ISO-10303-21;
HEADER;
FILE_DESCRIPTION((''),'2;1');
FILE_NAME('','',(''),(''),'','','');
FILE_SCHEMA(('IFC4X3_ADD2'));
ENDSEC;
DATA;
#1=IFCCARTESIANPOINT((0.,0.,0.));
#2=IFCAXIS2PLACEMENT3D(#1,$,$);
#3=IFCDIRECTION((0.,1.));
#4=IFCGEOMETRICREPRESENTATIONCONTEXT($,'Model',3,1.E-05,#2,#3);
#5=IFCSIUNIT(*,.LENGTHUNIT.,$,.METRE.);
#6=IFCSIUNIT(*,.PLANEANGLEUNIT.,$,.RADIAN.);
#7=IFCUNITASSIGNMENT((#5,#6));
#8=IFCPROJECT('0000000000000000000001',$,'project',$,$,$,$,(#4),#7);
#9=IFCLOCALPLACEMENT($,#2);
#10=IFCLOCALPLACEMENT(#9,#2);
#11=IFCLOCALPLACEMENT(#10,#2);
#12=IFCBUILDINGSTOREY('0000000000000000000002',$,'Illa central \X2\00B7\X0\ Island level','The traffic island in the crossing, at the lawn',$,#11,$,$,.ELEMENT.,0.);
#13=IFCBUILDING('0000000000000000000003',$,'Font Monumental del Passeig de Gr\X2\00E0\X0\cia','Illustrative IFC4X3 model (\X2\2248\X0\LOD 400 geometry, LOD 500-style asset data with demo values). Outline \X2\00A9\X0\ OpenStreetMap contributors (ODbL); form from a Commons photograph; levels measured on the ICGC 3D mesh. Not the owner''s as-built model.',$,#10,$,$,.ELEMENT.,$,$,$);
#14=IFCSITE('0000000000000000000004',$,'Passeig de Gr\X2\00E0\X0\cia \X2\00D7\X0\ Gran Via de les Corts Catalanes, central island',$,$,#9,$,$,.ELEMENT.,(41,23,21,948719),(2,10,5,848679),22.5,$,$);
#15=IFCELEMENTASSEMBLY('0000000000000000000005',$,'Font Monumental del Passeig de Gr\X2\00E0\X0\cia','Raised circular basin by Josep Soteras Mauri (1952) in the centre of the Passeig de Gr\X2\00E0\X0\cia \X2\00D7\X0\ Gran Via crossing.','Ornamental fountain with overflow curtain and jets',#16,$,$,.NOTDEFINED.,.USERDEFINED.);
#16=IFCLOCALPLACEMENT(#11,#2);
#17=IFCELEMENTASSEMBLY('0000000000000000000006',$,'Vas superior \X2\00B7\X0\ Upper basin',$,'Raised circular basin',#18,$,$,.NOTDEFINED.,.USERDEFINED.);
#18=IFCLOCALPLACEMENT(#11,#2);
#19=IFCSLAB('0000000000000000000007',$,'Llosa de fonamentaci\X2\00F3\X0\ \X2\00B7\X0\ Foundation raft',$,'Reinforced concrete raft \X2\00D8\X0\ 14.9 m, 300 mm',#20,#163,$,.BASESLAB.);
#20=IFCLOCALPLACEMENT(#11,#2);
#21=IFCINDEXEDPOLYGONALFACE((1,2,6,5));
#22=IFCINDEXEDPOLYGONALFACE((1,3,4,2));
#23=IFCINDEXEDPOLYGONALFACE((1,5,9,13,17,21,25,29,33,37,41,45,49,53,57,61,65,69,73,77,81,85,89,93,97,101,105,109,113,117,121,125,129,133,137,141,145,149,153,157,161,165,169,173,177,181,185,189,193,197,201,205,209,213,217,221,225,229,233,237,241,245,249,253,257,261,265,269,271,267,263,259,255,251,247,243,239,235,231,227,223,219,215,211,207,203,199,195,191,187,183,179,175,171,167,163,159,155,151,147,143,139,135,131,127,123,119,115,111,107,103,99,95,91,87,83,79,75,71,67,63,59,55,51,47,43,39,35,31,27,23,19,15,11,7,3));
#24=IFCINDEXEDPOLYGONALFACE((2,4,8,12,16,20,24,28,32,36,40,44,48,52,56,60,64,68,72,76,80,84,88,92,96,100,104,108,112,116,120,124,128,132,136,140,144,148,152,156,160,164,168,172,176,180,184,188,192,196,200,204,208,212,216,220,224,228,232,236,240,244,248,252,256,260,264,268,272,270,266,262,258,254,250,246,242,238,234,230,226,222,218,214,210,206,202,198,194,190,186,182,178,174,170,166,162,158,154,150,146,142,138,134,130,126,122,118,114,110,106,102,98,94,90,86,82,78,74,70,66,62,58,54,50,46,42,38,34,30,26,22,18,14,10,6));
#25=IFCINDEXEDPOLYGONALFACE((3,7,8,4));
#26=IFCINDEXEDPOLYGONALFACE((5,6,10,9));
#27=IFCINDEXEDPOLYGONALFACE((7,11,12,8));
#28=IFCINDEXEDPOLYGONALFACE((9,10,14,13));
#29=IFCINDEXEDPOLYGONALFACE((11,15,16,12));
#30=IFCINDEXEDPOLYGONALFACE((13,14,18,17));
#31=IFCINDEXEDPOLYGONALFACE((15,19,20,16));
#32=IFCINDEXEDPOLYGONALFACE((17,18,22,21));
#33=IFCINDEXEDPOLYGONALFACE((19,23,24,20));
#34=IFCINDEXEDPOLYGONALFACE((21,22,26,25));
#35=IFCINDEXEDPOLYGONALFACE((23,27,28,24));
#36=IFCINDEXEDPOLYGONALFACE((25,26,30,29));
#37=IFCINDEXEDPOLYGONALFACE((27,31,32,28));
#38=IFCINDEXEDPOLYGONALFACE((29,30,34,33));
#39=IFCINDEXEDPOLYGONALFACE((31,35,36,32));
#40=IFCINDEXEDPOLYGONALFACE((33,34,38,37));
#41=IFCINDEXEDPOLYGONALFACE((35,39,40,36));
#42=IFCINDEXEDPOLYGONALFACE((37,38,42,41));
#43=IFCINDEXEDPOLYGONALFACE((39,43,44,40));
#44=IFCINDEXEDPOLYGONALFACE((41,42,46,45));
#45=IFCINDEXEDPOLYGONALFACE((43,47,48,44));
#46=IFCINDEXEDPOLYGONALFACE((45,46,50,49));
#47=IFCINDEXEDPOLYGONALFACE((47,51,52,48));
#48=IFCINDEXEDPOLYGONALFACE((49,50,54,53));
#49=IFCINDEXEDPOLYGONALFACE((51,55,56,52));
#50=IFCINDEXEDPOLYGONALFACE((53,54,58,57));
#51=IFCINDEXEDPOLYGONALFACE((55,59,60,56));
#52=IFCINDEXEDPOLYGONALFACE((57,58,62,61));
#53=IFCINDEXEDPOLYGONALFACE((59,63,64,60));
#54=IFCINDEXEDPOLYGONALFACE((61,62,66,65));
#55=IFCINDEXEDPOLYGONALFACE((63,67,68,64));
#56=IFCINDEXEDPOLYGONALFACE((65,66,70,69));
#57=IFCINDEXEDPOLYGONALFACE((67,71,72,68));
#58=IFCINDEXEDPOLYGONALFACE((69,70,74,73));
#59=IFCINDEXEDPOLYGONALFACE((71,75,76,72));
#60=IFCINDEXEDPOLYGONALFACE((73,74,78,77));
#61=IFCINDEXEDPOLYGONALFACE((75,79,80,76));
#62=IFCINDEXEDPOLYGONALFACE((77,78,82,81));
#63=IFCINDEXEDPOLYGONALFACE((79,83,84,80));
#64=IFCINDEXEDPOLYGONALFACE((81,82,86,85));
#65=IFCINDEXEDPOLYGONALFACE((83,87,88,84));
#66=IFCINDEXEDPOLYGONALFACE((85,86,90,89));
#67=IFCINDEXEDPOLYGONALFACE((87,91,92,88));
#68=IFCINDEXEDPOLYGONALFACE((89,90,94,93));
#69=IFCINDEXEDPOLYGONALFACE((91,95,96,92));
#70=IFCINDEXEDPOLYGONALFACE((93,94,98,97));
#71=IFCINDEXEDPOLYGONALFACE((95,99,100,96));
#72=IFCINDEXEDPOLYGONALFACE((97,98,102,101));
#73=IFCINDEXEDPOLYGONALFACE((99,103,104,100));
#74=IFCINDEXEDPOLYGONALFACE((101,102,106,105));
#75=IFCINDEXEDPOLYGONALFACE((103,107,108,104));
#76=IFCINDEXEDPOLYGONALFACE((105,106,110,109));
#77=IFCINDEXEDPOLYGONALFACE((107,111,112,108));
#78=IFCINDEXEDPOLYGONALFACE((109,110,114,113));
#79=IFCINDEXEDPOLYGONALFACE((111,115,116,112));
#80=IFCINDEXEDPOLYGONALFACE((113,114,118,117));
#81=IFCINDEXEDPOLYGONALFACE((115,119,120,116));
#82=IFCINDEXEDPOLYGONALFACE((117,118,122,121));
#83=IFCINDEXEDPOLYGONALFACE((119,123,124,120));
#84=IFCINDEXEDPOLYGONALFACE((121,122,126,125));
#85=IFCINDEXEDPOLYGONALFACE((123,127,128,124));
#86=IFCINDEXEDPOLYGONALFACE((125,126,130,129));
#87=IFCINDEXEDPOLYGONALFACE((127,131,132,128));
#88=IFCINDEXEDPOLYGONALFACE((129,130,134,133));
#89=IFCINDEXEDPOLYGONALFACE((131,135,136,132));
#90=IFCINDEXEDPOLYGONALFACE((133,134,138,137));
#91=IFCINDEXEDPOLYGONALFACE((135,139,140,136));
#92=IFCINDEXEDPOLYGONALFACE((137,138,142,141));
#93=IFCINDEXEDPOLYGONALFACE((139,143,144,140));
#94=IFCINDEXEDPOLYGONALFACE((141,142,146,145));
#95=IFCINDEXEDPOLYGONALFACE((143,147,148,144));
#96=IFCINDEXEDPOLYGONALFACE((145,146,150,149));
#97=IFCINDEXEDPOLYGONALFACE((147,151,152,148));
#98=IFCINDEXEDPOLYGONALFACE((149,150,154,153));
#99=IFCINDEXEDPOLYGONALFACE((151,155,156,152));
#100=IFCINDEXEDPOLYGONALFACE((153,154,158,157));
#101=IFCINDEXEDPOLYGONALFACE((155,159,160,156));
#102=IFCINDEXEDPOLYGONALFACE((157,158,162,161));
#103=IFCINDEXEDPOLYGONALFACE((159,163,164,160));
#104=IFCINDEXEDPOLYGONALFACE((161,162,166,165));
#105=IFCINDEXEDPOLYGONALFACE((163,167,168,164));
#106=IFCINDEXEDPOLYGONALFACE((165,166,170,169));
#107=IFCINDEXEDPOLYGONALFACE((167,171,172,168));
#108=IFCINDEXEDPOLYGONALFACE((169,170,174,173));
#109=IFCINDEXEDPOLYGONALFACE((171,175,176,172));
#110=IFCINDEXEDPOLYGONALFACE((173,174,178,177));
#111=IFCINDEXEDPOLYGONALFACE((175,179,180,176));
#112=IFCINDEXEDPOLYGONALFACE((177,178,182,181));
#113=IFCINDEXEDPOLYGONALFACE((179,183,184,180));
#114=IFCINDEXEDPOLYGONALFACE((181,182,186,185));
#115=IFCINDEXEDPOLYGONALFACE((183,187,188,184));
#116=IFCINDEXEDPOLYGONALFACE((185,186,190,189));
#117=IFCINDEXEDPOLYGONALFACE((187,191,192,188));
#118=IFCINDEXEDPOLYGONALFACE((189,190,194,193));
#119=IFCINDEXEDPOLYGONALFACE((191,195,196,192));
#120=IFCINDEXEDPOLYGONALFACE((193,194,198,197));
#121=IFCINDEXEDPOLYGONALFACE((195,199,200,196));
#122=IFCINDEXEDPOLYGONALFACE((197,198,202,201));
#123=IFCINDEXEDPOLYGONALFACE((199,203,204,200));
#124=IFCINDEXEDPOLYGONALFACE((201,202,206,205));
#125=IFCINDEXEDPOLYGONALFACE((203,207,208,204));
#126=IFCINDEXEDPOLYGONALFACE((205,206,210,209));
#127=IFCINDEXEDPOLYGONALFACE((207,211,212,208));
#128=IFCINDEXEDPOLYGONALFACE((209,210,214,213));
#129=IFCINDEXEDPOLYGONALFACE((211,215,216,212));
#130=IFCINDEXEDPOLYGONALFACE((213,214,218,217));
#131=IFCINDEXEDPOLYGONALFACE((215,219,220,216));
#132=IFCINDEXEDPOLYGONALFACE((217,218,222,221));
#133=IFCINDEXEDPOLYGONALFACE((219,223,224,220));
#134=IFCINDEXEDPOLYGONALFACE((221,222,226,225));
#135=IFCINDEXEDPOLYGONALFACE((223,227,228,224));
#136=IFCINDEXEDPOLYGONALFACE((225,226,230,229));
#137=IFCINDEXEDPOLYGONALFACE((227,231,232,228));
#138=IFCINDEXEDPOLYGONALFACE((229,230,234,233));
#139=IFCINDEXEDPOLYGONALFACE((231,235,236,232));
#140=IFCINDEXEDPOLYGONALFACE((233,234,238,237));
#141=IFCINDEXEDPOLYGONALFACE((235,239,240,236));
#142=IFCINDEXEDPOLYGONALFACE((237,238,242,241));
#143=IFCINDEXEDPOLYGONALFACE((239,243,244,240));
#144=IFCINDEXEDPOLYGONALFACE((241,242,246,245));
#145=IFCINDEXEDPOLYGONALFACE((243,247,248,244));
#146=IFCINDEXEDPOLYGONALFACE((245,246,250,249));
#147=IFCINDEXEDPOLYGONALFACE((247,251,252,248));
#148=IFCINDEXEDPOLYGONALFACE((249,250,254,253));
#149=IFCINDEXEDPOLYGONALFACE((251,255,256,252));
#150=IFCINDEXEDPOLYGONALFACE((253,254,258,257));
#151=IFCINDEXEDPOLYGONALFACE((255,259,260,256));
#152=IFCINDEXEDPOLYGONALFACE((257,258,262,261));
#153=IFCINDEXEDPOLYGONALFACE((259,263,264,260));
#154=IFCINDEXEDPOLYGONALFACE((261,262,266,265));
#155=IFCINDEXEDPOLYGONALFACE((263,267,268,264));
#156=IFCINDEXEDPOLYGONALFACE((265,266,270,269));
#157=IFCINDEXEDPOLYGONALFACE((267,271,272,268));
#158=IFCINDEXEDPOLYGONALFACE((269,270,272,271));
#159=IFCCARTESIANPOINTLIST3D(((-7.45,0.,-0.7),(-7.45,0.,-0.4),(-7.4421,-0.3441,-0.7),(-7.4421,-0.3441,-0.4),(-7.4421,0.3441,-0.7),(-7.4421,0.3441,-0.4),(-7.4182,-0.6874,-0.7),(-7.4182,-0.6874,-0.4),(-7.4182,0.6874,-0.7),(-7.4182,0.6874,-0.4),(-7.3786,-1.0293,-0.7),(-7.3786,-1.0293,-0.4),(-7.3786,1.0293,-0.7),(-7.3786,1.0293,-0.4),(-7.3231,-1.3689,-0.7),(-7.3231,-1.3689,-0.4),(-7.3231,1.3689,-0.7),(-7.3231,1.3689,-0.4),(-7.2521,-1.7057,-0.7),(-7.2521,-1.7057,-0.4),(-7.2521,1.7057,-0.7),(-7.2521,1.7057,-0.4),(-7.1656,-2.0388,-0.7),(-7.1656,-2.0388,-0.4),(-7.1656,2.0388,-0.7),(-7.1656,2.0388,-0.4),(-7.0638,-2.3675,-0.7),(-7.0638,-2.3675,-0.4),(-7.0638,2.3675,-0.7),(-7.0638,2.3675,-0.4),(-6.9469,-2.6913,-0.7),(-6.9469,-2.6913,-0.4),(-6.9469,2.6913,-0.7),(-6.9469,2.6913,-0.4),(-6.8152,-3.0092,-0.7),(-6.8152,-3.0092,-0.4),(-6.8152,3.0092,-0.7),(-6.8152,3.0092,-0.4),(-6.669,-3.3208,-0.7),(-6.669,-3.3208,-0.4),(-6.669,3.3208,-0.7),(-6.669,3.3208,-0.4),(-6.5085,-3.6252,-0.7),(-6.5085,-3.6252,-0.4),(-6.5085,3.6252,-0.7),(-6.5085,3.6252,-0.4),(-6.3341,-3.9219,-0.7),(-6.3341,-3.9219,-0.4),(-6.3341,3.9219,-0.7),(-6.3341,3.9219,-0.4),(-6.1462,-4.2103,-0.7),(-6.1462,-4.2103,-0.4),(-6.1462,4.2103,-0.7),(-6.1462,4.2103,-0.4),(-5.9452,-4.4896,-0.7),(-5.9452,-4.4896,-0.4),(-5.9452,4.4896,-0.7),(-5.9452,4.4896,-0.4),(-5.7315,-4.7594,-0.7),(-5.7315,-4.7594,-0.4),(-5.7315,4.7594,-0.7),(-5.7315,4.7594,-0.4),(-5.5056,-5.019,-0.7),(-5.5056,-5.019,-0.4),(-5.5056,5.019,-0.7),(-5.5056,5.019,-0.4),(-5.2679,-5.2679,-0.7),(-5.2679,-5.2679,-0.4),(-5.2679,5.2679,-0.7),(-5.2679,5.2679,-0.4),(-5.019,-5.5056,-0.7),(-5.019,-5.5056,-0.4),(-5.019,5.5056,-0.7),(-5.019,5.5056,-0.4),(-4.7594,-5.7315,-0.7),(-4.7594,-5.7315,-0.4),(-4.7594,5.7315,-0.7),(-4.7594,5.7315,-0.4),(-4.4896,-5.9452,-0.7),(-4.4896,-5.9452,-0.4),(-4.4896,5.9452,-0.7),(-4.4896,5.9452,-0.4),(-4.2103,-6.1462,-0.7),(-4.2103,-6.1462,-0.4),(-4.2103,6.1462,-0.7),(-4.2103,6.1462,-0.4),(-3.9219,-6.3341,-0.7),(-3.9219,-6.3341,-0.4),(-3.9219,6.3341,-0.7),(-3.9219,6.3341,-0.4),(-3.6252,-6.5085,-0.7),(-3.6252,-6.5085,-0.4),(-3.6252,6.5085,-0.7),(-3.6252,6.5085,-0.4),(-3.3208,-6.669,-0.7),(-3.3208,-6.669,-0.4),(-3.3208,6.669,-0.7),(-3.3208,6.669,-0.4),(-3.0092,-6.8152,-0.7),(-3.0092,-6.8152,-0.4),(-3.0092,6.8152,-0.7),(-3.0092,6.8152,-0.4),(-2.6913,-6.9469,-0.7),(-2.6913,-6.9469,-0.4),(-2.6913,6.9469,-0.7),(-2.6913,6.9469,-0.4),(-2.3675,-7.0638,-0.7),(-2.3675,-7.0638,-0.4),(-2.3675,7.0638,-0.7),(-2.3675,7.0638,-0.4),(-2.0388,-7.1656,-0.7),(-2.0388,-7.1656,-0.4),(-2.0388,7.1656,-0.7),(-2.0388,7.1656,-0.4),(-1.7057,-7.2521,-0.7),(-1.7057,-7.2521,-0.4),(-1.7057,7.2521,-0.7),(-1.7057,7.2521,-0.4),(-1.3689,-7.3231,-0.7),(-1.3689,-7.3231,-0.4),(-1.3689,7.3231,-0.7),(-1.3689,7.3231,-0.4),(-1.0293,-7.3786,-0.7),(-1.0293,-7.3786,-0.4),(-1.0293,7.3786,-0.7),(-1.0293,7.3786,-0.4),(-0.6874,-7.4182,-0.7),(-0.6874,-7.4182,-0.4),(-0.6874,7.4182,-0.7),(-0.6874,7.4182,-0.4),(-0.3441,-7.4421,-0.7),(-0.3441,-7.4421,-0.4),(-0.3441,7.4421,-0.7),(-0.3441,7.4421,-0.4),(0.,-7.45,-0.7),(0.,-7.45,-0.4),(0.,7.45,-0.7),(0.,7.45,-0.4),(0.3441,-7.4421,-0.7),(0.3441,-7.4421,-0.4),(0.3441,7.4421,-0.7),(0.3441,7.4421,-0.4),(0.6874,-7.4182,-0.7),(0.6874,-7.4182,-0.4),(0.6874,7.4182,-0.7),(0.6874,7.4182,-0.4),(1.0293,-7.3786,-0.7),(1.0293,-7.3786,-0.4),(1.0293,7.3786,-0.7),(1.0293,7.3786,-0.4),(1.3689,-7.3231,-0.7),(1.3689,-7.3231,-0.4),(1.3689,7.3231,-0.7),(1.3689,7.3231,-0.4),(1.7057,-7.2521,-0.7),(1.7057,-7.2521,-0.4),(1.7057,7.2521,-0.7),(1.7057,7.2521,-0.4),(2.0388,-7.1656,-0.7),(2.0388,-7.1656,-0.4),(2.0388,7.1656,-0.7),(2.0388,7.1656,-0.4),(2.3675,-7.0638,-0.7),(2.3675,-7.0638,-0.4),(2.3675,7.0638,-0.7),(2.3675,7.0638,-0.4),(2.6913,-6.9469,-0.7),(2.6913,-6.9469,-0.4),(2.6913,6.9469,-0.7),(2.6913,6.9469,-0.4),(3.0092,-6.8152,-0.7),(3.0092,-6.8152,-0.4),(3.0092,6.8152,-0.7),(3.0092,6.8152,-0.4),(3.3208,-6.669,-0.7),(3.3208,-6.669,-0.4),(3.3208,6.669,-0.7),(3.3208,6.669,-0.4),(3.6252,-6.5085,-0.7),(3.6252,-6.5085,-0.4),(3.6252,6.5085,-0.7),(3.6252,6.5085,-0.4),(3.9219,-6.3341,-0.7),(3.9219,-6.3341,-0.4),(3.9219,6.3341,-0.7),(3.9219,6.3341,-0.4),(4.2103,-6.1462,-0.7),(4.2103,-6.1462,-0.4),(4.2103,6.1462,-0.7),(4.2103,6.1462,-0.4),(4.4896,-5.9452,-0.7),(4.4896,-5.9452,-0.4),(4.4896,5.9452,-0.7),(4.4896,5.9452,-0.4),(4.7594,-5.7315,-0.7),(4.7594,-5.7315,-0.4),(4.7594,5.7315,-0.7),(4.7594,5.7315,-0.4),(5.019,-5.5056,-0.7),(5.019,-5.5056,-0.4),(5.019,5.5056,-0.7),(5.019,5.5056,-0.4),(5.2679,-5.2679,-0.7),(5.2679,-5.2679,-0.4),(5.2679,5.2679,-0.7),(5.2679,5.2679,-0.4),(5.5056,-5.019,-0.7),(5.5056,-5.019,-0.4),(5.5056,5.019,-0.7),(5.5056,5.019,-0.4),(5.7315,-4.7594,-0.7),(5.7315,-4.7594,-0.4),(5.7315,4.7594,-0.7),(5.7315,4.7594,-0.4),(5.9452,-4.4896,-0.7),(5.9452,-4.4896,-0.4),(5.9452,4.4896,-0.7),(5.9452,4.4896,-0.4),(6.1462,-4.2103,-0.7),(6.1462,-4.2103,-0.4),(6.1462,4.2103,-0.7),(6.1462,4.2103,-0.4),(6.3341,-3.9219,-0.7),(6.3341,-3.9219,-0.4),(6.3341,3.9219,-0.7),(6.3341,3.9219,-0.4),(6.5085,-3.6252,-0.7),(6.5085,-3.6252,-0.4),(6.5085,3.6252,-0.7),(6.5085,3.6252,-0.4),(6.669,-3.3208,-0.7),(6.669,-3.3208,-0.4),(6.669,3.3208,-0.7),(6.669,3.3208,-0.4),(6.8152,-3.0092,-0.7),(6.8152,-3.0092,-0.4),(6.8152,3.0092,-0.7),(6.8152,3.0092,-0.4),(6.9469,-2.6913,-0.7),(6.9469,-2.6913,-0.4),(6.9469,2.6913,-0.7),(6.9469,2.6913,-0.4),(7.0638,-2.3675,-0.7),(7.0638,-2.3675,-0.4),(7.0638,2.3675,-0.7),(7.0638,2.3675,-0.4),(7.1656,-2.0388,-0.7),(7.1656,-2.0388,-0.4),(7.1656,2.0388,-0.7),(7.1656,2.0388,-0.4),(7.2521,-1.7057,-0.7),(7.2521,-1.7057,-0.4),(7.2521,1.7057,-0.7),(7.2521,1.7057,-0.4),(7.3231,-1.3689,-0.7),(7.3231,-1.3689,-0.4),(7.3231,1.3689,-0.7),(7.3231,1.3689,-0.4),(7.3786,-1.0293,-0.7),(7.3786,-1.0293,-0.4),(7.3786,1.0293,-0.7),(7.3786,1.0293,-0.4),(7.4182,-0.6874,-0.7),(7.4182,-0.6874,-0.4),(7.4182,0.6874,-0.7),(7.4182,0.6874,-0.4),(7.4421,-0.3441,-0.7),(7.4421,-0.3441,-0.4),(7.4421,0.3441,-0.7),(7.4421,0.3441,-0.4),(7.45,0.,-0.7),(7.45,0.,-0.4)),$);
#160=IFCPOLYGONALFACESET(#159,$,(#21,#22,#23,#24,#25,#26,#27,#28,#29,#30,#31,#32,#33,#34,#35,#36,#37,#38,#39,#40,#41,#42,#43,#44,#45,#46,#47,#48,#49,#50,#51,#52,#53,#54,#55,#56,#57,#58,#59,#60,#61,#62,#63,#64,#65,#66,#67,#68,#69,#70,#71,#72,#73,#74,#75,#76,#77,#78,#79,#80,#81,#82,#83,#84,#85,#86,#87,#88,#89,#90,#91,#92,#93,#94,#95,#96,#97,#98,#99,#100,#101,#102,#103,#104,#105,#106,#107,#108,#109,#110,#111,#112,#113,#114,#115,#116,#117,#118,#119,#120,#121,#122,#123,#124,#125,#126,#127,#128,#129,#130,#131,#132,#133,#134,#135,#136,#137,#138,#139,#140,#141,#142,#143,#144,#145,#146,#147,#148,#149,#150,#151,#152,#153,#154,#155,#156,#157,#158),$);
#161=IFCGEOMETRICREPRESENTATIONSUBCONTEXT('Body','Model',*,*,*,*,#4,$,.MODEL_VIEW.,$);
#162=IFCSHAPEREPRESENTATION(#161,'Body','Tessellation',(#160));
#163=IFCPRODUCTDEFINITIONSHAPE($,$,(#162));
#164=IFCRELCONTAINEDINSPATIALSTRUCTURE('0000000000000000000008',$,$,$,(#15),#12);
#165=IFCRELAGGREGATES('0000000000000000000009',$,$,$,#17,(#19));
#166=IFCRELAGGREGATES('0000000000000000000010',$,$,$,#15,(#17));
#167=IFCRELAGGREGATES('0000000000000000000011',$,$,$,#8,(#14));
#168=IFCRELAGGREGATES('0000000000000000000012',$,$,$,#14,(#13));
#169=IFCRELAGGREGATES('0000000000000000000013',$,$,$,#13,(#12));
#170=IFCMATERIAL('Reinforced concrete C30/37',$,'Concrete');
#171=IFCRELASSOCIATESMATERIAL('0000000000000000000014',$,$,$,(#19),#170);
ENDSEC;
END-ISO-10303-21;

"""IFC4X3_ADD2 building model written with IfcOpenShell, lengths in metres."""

from ifc_helpers import new_model, si_unit, direction, frame, origin, origin_2d_with_axis, place, context, subcontext, project, spatial, circle, extrude, material, element, aggregate, save


model = new_model("IFC4X3_ADD2")

# Units and contexts
model_context = context("Model", 3, precision=1e-05, world=origin(), true_north=direction((0.0, 1.0)))
body_context = subcontext(model_context, "Body", "Model", "MODEL_VIEW")
ifc_project = project(units=[si_unit("LENGTHUNIT", "METRE"), si_unit("PLANEANGLEUNIT", "RADIAN")], contexts=[model_context])

# Site, building, storey
site_placement = place(None, origin())
site = spatial("IfcSite", under=ifc_project, at=site_placement, Name="Passeig de Gràcia × Gran Via de les Corts Catalanes, central island", CompositionType="ELEMENT", RefLatitude=(41, 23, 21, 948719), RefLongitude=(2, 10, 5, 848679), RefElevation=22.5)
building_placement = place(site_placement, origin())
building = spatial("IfcBuilding", under=site, at=building_placement, Name="Font Monumental del Passeig de Gràcia", Description="Illustrative IFC4X3 model (≈LOD 400 geometry, LOD 500-style asset data with demo values). Outline © OpenStreetMap contributors (ODbL); form from a Commons photograph; levels measured on the ICGC 3D mesh. Not the owner's as-built model.", CompositionType="ELEMENT")
storey_placement = place(building_placement, origin())
storey = spatial("IfcBuildingStorey", under=building, at=storey_placement, Name="Illa central · Island level", Description="The traffic island in the crossing, at the lawn", CompositionType="ELEMENT", Elevation=0.0)

# Element assemblies, slab
assembly_1_placement = place(building_placement, origin())
assembly_1 = element("IfcElementAssembly", 1, at=assembly_1_placement, inside=storey, Name="Font Monumental del Passeig de Gràcia", Description="Raised circular basin by Josep Soteras Mauri (1952) in the centre of the Passeig de Gràcia × Gran Via crossing.", ObjectType="Ornamental fountain with overflow curtain and jets", AssemblyPlace="NOTDEFINED", PredefinedType="USERDEFINED")
assembly_2_placement = place(building_placement, origin())
assembly_2 = element("IfcElementAssembly", 2, at=assembly_2_placement, Name="Vas superior · Upper basin", ObjectType="Raised circular basin", AssemblyPlace="NOTDEFINED", PredefinedType="USERDEFINED")
ifc_material_1 = material(Name="Reinforced concrete C30/37", Category="Concrete")
slab_1_placement = place(building_placement, origin())
slab_1 = element("IfcSlab", 3, at=slab_1_placement, material=ifc_material_1, Name="Llosa de fonamentació · Foundation raft", ObjectType="Reinforced concrete raft Ø 14.9 m, 300 mm", PredefinedType="BASESLAB", context=body_context, shape_type="SweptSolid", body=[
    extrude(circle(Radius=7.45, at=origin_2d_with_axis()), frame((0.0, 0.0, -0.7)), (0.0, 0.0, 1.0), 0.3),
])
aggregate(assembly_2, [slab_1])
aggregate(assembly_1, [assembly_2])

save(model, "model.ifc")
